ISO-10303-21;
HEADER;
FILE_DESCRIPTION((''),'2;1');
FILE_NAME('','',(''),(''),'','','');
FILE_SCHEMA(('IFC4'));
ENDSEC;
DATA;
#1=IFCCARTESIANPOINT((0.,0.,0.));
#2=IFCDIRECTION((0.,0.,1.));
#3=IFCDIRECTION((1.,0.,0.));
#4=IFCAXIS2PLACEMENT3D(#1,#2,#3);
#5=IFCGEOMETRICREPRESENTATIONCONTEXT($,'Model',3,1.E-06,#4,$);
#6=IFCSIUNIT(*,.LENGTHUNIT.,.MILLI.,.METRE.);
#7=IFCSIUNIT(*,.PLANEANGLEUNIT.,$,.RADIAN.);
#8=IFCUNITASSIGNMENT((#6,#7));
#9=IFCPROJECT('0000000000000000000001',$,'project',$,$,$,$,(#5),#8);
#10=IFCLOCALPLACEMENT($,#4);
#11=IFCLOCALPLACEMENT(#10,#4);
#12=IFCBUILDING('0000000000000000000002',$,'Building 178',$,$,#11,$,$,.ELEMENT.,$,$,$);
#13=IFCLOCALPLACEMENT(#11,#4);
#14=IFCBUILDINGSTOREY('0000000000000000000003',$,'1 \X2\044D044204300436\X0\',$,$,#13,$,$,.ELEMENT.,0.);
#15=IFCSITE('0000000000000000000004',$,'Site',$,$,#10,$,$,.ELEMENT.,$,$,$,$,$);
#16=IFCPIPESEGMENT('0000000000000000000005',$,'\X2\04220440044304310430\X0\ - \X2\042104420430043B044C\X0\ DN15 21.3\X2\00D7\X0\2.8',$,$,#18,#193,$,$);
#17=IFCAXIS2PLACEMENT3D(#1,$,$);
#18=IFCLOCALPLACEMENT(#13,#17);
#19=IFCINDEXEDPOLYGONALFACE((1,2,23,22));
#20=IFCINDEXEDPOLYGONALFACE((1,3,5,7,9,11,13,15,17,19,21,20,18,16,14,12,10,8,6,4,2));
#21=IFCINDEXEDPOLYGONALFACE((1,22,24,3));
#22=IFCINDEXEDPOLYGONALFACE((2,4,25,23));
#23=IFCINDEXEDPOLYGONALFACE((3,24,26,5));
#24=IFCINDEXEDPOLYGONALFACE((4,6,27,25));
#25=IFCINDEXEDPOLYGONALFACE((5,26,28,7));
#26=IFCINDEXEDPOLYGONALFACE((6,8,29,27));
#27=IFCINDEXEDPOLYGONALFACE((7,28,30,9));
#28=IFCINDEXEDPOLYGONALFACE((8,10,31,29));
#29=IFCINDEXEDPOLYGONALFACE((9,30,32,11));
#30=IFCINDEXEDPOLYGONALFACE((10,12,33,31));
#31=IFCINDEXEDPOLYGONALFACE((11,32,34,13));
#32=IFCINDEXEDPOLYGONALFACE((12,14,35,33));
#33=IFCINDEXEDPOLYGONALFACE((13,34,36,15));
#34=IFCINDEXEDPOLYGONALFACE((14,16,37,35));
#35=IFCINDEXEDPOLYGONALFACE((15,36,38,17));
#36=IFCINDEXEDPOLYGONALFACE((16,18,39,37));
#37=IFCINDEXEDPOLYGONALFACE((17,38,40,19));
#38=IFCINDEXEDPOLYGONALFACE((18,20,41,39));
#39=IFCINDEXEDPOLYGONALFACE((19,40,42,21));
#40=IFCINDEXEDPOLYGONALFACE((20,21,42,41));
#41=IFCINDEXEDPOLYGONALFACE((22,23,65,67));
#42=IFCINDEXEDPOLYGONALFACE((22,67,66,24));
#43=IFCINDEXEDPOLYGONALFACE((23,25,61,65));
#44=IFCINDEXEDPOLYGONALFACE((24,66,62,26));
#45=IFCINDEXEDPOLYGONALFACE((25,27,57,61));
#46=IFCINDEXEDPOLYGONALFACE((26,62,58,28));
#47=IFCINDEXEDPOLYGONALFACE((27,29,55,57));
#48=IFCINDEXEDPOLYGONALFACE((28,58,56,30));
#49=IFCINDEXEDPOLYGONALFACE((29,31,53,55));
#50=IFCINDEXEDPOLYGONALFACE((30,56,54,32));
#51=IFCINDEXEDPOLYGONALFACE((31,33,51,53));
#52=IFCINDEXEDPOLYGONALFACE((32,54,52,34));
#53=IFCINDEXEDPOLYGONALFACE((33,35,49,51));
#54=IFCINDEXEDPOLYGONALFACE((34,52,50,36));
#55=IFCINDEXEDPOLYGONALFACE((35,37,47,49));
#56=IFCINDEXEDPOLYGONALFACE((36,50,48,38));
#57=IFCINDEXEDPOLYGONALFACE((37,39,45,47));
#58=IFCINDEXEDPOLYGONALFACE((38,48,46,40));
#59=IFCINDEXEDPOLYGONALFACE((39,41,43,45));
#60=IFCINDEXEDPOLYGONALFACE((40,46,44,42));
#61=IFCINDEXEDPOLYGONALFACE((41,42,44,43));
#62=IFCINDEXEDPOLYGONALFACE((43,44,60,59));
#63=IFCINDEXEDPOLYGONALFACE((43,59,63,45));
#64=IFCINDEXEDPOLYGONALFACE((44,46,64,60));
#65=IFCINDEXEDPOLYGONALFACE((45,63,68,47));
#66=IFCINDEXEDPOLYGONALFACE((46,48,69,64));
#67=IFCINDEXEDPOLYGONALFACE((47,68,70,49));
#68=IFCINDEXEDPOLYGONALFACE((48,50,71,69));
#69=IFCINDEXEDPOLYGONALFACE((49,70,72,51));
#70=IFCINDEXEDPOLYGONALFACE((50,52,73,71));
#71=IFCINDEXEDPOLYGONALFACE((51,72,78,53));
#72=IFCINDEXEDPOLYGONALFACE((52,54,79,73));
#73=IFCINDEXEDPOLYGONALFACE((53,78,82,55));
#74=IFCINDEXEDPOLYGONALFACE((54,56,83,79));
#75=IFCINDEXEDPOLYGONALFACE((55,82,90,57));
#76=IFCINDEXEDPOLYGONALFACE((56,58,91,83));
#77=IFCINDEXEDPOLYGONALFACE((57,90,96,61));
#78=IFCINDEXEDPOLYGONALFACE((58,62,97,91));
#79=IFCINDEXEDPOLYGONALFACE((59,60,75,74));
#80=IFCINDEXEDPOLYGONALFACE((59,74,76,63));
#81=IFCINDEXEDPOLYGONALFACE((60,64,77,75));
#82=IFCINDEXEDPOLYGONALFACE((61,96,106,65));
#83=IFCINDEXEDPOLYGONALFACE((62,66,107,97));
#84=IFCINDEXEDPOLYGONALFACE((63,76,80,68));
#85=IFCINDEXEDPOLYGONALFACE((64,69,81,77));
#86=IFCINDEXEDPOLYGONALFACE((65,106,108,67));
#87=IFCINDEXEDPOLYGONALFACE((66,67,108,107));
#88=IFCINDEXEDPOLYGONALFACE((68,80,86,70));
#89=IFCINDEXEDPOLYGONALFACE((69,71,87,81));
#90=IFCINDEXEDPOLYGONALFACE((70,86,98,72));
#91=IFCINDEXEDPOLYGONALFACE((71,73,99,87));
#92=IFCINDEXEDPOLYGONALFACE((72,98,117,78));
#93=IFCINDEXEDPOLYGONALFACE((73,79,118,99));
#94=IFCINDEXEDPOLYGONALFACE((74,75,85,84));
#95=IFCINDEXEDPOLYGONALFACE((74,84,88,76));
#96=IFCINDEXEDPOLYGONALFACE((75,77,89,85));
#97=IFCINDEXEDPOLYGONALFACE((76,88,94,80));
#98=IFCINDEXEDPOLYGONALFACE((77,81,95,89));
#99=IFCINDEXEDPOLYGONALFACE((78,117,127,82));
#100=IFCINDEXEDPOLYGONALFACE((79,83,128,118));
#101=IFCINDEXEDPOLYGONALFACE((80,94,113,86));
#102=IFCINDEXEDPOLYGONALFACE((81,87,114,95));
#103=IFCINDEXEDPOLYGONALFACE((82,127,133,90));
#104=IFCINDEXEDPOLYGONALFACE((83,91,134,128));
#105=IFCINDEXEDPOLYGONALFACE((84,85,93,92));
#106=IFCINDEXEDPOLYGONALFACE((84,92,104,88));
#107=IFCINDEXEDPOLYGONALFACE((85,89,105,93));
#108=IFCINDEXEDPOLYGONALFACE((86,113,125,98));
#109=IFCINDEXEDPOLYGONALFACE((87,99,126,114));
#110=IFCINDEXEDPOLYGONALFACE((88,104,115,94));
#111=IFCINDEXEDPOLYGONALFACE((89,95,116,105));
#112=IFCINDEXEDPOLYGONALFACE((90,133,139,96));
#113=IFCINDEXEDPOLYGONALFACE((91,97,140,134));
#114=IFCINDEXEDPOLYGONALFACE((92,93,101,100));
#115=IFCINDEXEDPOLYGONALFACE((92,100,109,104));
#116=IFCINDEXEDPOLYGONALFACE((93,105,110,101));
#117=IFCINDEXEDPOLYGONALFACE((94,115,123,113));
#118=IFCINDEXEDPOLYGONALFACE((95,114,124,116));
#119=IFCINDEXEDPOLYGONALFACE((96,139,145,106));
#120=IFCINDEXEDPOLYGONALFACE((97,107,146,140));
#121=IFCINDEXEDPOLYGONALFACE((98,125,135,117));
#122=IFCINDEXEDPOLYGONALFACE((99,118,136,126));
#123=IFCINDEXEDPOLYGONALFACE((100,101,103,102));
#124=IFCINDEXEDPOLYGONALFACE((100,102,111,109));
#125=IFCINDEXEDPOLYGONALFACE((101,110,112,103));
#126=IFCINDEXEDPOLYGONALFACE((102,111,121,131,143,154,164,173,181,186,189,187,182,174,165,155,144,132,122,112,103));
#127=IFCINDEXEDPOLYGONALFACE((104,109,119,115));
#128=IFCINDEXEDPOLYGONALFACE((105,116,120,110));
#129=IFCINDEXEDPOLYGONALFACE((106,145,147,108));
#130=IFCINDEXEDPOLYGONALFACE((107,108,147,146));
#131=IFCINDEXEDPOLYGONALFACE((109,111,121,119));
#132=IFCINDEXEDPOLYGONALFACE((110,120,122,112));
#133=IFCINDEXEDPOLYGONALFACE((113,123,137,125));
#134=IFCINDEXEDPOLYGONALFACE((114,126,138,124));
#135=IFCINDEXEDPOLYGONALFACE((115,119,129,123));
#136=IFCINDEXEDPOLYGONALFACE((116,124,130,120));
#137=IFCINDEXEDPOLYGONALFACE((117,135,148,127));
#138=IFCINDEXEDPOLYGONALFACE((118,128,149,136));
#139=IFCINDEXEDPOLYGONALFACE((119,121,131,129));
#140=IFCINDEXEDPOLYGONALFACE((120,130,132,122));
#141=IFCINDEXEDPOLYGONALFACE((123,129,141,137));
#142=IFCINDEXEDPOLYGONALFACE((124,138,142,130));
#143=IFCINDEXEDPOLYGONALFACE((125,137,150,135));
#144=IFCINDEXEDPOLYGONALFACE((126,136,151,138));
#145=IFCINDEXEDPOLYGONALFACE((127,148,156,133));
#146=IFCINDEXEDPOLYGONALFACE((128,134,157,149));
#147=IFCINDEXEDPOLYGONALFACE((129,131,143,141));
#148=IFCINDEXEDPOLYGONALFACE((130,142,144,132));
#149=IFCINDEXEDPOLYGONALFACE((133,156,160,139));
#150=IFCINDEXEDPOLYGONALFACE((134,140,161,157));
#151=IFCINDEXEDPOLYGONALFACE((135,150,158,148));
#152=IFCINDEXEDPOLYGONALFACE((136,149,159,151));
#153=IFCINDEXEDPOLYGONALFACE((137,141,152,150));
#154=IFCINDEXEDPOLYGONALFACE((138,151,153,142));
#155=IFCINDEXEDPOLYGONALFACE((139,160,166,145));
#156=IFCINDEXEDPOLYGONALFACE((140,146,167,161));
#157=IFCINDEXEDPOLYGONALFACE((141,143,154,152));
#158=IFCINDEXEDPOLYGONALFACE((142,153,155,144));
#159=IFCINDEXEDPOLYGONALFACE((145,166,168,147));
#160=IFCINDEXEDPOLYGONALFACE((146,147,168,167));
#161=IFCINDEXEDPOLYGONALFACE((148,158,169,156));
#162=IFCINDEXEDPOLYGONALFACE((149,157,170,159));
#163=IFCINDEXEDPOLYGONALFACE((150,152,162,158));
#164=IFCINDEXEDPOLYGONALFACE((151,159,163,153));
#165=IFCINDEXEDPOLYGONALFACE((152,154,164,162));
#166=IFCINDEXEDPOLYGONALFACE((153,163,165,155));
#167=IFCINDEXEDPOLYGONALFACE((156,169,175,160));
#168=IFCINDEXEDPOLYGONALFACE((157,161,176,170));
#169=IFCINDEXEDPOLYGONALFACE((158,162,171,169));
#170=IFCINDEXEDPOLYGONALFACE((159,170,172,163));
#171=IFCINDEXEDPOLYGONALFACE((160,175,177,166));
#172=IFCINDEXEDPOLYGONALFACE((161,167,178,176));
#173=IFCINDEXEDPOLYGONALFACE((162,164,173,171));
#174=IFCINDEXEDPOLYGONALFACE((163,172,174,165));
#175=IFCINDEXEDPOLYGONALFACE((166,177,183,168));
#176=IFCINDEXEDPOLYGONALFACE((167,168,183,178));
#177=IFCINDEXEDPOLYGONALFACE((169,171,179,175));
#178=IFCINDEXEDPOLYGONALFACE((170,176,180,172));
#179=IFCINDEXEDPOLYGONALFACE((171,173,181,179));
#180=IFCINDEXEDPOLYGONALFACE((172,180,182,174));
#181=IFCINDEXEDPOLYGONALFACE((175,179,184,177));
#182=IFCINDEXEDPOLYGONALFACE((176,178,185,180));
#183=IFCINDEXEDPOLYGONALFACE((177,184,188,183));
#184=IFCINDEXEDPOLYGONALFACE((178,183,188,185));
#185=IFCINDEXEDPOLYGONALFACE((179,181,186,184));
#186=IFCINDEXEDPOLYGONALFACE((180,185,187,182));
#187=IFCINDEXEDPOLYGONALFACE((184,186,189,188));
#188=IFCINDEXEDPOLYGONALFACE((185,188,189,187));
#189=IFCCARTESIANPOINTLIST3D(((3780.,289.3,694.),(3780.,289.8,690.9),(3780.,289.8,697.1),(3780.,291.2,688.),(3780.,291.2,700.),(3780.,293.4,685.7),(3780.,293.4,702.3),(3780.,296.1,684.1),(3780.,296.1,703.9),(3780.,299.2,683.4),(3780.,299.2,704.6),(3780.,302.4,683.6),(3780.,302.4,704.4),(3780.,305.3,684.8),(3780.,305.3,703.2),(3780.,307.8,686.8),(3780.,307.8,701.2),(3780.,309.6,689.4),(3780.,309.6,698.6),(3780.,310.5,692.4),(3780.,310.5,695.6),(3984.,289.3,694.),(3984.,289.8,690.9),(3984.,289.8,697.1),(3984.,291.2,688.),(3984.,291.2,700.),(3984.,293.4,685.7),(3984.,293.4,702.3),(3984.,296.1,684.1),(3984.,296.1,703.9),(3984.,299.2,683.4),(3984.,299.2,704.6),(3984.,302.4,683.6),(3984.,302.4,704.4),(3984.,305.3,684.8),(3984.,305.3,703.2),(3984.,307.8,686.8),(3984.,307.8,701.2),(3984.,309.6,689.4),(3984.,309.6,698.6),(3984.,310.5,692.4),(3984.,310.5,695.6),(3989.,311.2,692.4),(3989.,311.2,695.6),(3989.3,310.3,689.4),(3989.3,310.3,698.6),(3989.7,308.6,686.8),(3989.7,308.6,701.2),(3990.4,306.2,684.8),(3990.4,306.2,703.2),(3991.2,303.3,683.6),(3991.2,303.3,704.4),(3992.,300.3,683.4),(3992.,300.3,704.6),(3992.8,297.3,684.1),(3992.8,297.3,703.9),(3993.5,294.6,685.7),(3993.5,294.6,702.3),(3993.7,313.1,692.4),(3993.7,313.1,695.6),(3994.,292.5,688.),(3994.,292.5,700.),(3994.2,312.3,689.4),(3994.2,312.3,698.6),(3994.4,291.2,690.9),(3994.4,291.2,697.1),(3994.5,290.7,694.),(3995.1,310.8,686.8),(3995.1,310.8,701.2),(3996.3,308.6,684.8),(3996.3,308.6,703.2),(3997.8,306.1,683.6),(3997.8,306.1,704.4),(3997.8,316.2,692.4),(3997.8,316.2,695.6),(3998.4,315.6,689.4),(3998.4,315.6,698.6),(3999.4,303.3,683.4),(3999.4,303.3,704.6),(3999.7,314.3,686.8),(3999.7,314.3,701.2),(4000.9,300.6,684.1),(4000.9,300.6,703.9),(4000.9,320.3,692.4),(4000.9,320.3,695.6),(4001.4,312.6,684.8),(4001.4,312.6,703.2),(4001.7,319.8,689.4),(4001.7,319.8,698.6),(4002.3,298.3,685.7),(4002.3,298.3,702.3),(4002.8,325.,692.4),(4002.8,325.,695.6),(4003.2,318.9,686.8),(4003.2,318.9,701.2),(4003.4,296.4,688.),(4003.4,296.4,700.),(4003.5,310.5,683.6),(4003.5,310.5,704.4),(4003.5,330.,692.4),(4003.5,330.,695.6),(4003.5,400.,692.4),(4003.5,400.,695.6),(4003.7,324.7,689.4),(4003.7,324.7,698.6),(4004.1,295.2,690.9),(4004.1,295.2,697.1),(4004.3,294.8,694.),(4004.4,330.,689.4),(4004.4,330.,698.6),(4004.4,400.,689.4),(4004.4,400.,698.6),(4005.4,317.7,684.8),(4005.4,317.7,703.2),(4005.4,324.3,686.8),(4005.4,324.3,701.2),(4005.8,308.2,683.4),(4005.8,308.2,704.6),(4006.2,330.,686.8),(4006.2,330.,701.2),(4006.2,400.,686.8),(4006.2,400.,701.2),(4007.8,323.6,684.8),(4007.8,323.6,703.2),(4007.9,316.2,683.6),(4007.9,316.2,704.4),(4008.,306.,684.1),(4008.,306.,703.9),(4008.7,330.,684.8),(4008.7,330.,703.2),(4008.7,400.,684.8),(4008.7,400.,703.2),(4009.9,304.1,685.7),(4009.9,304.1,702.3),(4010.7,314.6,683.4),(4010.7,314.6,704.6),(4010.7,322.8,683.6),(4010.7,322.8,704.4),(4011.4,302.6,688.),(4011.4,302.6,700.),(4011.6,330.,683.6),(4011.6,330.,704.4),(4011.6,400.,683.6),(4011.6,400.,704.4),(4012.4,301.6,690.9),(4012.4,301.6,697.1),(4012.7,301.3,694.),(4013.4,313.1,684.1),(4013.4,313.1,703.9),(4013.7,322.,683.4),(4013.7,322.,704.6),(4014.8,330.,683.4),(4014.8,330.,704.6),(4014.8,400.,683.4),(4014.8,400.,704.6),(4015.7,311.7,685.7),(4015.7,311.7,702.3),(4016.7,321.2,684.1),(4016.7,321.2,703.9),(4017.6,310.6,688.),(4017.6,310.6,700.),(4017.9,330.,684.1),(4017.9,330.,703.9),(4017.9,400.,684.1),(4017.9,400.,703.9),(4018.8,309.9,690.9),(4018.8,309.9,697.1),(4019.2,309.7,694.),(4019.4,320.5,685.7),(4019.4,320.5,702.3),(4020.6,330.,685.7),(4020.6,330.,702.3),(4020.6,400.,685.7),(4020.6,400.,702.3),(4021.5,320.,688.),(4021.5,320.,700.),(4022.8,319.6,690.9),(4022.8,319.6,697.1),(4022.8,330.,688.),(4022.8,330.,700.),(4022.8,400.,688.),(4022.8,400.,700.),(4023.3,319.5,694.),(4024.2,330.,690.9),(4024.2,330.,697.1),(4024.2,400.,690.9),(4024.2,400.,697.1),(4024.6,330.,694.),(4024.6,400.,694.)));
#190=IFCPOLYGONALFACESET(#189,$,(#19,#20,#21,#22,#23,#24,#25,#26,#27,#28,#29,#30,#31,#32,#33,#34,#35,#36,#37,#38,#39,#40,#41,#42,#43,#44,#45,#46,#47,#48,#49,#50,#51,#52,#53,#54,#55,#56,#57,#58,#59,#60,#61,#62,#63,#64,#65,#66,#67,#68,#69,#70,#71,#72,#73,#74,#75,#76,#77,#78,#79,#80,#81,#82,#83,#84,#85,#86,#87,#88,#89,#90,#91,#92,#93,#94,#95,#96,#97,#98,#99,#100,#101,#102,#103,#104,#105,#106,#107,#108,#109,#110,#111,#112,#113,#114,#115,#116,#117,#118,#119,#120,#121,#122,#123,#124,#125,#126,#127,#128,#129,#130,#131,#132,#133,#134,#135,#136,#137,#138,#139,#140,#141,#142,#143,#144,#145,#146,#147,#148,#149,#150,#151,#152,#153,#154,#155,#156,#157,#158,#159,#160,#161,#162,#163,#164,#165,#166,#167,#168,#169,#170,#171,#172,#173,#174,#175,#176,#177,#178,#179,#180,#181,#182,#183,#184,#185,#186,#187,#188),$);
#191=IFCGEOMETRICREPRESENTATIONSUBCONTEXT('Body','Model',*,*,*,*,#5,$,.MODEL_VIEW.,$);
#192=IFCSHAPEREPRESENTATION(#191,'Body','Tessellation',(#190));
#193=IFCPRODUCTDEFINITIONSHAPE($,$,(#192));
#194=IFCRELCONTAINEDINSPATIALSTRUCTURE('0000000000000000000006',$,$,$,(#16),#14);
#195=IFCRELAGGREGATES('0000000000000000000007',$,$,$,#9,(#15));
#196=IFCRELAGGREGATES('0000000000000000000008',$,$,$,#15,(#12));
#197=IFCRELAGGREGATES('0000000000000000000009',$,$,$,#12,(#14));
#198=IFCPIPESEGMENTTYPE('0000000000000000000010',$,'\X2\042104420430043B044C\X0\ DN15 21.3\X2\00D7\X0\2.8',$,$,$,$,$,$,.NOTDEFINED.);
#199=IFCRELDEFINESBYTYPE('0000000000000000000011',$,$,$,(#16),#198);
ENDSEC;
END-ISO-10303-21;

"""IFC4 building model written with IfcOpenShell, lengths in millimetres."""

from ifc_helpers import new_model, entity, si_unit, frame, origin_with_axes, place, context, subcontext, project, spatial, source, transform, mapped, type_object, element, save


model = new_model("IFC4")

# Units and contexts
model_context = context("Model", 3, precision=1e-06, world=origin_with_axes())
body_context = subcontext(model_context, "Body", "Model", "MODEL_VIEW")
ifc_project = project(units=[si_unit("LENGTHUNIT", "METRE", prefix="MILLI"), si_unit("PLANEANGLEUNIT", "RADIAN")], contexts=[model_context])

# Site, building, storey
site_placement = place(None, origin_with_axes())
site = spatial("IfcSite", under=ifc_project, at=site_placement, Name="Site", CompositionType="ELEMENT")
building_placement = place(site_placement, origin_with_axes())
building = spatial("IfcBuilding", under=site, at=building_placement, Name="Building 178", CompositionType="ELEMENT")
storey_placement = place(building_placement, origin_with_axes())
storey = spatial("IfcBuildingStorey", under=building, at=storey_placement, Name="1 этаж", CompositionType="ELEMENT", Elevation=0.0)

# Pipe segment
pipe_segment_type = type_object("IfcPipeSegmentType", Name="Сталь DN15 21.3×2.8", PredefinedType="NOTDEFINED")
shared_shape_1 = source(origin_with_axes(), body_context, "Body", "AdvancedSweptSolid", [
    entity("IfcSweptDiskSolid", entity("IfcIndexedPolyCurve", entity("IfcCartesianPointList3D", [[0.0, 0.0, 0.0], [0.0, 0.0, -70.0], [8.8, 0.0, -91.2], [30.0, 0.0, -100.0], [234.0, 0.0, -100.0]]), [entity("IfcLineIndex", [1, 2]), entity("IfcArcIndex", [2, 3, 4]), entity("IfcLineIndex", [4, 5])]), 10.7),
])
for number, where, z_axis, x_axis, name in (
    (1, (4014.0, 400.0, 694.0), (0.0, 1.0, 0.0), (-1.0, 0.0, 0.0), "Труба - Сталь DN15 21.3×2.8"),
):
    element("IfcPipeSegment", number, at=place(storey_placement, frame(where, z_axis=z_axis, x_axis=x_axis)), inside=storey, type_object=pipe_segment_type, Name=name, context=body_context, shape_type="MappedRepresentation", body=[
        mapped(shared_shape_1, transform((0.0, 0.0, 0.0), x_axis=(1.0, 0.0, 0.0), y_axis=(0.0, 1.0, 0.0), z_axis=(0.0, 0.0, 1.0), scale=1.0)),
    ])

save(model, "model.ifc")
